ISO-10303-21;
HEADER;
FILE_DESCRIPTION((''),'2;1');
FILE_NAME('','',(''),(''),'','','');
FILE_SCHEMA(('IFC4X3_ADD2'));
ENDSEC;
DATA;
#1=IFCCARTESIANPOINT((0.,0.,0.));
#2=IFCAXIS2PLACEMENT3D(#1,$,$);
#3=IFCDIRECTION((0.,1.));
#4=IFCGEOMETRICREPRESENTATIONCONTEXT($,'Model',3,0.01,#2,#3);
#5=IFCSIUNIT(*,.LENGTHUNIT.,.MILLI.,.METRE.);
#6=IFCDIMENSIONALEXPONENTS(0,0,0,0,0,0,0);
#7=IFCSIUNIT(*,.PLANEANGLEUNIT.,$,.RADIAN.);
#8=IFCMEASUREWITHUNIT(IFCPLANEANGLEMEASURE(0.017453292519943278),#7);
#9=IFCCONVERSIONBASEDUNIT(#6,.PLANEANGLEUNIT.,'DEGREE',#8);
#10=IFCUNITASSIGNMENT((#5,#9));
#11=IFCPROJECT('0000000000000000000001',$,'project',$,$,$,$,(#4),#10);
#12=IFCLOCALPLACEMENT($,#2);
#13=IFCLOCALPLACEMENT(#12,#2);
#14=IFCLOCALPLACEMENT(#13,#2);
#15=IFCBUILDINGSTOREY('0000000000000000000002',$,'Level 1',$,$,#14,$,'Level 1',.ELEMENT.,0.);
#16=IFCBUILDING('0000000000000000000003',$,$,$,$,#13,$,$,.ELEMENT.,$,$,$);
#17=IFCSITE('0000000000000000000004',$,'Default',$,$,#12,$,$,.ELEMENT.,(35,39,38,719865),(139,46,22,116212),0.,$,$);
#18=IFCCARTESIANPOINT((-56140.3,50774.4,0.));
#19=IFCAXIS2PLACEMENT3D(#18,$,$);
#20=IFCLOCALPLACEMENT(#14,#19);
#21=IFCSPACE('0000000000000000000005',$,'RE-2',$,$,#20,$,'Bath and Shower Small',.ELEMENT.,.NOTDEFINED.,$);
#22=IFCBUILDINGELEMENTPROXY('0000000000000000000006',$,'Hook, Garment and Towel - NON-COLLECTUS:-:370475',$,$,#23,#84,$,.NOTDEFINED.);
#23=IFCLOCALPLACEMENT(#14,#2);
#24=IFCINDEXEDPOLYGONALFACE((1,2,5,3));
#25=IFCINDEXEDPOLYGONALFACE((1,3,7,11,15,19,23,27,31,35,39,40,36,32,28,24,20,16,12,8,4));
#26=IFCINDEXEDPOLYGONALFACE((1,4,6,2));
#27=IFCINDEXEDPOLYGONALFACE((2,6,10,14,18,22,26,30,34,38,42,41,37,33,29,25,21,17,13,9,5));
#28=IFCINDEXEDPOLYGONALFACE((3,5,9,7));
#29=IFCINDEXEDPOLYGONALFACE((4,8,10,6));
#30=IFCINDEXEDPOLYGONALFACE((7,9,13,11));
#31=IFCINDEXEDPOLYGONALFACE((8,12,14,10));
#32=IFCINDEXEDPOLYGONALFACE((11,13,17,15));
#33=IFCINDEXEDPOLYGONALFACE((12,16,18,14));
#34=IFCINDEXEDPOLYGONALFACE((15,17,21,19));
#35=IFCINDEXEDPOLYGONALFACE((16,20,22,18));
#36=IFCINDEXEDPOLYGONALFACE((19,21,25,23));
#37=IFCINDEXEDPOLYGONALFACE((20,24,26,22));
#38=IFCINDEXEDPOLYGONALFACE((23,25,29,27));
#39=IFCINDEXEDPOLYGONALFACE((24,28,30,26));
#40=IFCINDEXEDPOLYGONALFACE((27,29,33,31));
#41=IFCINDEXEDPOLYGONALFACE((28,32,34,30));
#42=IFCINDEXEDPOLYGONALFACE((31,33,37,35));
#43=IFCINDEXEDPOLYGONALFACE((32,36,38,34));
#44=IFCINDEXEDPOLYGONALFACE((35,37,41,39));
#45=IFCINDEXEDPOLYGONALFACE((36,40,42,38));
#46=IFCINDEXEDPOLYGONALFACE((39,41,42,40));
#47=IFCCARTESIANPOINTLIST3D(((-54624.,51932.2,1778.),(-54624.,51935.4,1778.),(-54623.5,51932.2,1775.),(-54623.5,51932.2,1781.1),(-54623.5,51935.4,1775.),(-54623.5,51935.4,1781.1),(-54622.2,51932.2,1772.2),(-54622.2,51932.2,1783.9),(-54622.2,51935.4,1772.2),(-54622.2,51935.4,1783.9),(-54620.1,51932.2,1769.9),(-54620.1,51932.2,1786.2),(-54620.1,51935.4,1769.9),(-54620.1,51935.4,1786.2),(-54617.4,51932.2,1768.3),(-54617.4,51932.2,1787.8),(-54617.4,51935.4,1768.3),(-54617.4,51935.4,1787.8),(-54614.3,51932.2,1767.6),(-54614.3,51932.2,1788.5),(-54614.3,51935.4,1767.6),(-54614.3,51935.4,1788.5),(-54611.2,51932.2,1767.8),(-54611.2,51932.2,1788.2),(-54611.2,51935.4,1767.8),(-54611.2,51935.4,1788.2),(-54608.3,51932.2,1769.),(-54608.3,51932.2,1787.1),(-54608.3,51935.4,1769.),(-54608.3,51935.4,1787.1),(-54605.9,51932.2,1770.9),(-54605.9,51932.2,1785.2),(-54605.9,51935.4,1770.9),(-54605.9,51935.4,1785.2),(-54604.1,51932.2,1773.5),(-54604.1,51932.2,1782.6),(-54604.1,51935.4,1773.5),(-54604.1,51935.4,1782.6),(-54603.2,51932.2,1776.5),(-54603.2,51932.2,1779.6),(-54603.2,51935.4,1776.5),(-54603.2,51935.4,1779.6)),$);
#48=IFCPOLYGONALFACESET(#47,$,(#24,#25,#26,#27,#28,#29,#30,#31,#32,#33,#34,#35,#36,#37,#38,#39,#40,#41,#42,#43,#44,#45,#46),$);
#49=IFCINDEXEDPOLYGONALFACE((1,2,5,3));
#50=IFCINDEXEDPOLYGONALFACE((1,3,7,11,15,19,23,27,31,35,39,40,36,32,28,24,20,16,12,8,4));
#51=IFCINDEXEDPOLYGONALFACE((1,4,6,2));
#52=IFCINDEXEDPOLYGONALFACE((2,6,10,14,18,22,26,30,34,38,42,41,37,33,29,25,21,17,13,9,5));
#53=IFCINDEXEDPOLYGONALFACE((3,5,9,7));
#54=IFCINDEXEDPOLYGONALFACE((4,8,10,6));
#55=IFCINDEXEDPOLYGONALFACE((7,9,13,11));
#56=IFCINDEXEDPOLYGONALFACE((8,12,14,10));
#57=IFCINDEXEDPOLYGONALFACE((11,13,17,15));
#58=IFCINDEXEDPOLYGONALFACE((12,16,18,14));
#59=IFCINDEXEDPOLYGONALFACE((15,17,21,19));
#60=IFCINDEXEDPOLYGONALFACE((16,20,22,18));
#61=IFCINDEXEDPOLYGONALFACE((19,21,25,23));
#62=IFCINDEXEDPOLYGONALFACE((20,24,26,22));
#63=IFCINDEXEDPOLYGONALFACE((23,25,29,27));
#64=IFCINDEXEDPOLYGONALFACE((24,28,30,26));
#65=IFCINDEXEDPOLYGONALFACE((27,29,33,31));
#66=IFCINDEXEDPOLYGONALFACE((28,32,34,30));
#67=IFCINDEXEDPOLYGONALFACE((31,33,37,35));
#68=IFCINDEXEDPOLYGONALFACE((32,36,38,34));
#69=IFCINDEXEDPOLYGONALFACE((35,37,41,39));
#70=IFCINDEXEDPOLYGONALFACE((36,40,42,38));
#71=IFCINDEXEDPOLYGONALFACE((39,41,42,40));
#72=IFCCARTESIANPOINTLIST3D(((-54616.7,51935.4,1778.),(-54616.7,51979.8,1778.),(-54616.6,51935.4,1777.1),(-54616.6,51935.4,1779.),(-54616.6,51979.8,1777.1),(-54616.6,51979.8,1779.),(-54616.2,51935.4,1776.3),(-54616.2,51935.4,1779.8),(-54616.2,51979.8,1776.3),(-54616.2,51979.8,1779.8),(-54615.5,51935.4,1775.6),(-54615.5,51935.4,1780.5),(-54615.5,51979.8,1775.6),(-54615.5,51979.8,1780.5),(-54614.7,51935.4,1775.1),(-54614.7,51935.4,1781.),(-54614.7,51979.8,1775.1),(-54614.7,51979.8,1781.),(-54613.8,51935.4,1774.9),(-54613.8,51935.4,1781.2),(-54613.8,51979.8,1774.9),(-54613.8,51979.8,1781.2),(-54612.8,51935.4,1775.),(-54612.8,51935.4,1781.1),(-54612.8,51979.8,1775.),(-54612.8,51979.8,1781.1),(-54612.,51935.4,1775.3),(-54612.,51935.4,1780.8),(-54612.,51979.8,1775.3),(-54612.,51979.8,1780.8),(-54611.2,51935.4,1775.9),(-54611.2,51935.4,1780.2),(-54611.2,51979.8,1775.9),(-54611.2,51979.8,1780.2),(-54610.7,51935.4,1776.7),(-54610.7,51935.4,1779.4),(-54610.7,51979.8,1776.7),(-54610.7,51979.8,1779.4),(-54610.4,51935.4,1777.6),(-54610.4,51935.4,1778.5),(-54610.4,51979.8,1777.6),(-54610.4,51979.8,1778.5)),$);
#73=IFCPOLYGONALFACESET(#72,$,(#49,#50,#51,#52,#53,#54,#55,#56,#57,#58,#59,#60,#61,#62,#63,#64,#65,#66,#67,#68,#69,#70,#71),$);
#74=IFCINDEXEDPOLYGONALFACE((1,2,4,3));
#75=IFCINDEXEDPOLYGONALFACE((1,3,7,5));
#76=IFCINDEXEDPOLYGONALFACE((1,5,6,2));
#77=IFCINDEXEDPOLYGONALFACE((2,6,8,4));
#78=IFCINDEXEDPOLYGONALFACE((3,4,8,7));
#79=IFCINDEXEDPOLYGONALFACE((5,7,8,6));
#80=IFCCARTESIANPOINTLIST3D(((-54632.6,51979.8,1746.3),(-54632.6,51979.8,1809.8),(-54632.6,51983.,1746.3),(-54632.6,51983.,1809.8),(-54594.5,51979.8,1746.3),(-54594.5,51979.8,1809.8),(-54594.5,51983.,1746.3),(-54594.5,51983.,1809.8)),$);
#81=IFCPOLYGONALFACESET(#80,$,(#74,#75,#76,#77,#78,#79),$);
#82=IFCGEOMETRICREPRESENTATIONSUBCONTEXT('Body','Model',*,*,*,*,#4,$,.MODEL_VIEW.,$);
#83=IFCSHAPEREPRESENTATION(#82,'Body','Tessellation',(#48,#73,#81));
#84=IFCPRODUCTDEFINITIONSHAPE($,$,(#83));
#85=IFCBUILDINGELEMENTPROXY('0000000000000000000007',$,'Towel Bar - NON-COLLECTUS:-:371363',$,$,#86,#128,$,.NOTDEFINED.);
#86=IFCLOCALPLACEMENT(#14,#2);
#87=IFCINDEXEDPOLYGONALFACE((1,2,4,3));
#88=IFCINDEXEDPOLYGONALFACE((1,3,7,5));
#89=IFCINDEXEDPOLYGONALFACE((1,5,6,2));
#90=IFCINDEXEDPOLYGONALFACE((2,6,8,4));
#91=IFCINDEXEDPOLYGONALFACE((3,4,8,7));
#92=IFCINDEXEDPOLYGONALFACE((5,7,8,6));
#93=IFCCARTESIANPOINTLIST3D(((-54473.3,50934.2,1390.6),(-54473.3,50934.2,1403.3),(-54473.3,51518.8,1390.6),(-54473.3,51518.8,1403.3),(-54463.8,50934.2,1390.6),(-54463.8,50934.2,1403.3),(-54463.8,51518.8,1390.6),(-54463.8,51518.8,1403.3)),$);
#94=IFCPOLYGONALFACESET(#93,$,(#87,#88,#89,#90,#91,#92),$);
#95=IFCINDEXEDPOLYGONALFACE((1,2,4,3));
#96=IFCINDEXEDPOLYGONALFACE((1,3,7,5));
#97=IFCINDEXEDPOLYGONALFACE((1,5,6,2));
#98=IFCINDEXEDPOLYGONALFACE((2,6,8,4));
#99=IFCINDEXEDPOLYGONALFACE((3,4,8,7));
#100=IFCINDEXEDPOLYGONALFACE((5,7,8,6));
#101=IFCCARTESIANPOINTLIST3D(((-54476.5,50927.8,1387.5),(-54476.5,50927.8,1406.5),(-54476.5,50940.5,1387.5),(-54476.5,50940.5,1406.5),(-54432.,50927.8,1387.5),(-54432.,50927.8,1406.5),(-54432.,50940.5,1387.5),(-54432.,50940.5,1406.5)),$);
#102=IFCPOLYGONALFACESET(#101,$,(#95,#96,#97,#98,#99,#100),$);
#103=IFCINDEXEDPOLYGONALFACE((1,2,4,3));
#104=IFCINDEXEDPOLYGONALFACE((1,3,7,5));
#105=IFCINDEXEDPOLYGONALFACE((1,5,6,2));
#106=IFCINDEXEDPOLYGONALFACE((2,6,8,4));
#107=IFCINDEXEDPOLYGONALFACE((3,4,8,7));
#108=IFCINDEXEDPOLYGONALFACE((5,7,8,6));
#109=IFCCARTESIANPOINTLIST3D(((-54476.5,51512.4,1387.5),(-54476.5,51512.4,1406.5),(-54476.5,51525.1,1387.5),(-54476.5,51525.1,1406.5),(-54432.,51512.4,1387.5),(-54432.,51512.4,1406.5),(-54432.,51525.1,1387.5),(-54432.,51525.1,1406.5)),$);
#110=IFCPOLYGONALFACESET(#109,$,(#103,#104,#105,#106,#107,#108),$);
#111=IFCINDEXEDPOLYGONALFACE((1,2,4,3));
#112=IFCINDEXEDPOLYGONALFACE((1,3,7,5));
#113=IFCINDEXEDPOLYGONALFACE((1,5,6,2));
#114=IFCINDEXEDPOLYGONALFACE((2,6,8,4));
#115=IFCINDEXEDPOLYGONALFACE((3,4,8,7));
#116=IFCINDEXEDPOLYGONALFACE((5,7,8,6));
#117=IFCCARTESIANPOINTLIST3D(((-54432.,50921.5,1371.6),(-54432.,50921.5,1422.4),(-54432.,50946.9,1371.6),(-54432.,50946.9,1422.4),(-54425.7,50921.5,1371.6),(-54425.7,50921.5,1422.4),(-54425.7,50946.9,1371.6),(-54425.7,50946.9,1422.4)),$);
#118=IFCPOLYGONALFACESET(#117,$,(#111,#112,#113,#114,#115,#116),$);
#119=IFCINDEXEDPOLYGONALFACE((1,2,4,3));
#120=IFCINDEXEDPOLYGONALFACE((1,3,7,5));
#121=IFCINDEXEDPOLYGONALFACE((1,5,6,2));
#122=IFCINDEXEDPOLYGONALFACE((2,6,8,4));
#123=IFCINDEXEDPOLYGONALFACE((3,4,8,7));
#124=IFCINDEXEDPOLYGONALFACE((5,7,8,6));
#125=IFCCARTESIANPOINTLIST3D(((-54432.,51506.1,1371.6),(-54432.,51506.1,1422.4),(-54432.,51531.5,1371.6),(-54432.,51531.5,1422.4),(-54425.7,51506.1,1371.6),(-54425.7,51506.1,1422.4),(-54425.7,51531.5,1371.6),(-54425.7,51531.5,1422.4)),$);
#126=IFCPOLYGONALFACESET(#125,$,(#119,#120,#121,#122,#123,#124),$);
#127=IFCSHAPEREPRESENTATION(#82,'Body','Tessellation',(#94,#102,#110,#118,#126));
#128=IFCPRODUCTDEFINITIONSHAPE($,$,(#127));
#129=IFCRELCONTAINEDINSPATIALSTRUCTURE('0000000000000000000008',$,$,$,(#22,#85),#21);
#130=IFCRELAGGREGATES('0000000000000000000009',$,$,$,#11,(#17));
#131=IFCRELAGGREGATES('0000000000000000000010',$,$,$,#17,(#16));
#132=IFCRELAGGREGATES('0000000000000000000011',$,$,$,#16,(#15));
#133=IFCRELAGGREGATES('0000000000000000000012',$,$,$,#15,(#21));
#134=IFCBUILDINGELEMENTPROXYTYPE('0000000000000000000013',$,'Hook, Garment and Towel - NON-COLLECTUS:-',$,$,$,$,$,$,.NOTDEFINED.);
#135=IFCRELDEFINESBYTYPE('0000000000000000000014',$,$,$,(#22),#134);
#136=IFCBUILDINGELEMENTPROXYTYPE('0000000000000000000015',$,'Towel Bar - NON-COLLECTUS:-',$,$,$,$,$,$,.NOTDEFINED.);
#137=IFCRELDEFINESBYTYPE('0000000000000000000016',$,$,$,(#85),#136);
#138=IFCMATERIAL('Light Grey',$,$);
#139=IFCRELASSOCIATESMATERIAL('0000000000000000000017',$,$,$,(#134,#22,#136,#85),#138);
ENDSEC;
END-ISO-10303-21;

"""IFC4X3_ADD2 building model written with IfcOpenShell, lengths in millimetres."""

from ifc_helpers import new_model, entity, si_unit, converted_unit, direction, frame, frame_2d, origin, origin_2d_with_axis, place, context, subcontext, project, spatial, rectangle, circle, extrude, source, transform, mapped, material, type_object, type_shapes, element, save


model = new_model("IFC4X3_ADD2")

# Units and contexts
model_context = context("Model", 3, precision=0.01, world=origin(), true_north=direction((0.0, 1.0)))
body_context = subcontext(model_context, "Body", "Model", "MODEL_VIEW")
ifc_project = project(units=[si_unit("LENGTHUNIT", "METRE", prefix="MILLI"), converted_unit("PLANEANGLEUNIT", "DEGREE", entity("IfcPlaneAngleMeasure", 0.017453292519943278), si_unit("PLANEANGLEUNIT", "RADIAN"), dimensions=[0, 0, 0, 0, 0, 0, 0])], contexts=[model_context])

# Site, building, storey
site_placement = place(None, origin())
site = spatial("IfcSite", under=ifc_project, at=site_placement, Name="Default", CompositionType="ELEMENT", RefLatitude=(35, 39, 38, 719865), RefLongitude=(139, 46, 22, 116212), RefElevation=0.0)
building_placement = place(site_placement, origin())
building = spatial("IfcBuilding", under=site, at=building_placement, CompositionType="ELEMENT")
storey_placement = place(building_placement, origin())
storey = spatial("IfcBuildingStorey", under=building, at=storey_placement, Name="Level 1", LongName="Level 1", CompositionType="ELEMENT", Elevation=0.0)

# Shared definitions
space_1_placement = place(storey_placement, frame((-56140.3, 50774.4, 0.0)))
space_1 = spatial("IfcSpace", under=storey, at=space_1_placement, Name="RE-2", LongName="Bath and Shower Small", CompositionType="ELEMENT", PredefinedType="NOTDEFINED")

# Building element proxies
ifc_material_1 = material(Name="Light Grey")
building_element_proxy_type_1 = type_object("IfcBuildingElementProxyType", Name="Hook, Garment and Towel - NON-COLLECTUS:-", PredefinedType="NOTDEFINED", material=ifc_material_1)
shared_shape_1 = source(origin(), body_context, "Body", "SweptSolid", [
    extrude(circle(Radius=10.5, at=frame_2d((0.0, 0.0), x_axis=(1.0, 0.0))), frame((19.1, -50.8, 31.8), z_axis=(0.0, 1.0, 0.0), x_axis=(-1.0, 0.0, 0.0)), (0.0, 0.0, 1.0), 3.2),
    extrude(circle(Radius=3.2, at=frame_2d((0.0, 0.0), x_axis=(1.0, 0.0))), frame((19.1, -47.6, 31.8), z_axis=(0.0, 1.0, 0.0), x_axis=(-1.0, 0.0, 0.0)), (0.0, 0.0, 1.0), 44.5),
    extrude(rectangle(XDim=3.2, YDim=38.1, at=origin_2d_with_axis()), frame((19.1, -1.6, 0.0), z_axis=(0.0, 0.0, 1.0), x_axis=(0.0, 1.0, 0.0)), (0.0, 0.0, 1.0), 63.5),
])
type_shapes(building_element_proxy_type_1, [shared_shape_1])
proxy_1_placement = place(space_1_placement, frame((1507.7, 1208.6, 1746.3)))
element("IfcBuildingElementProxy", 1, at=proxy_1_placement, inside=space_1, type_object=building_element_proxy_type_1, material=ifc_material_1, Name="Hook, Garment and Towel - NON-COLLECTUS:-:370475", PredefinedType="NOTDEFINED", context=body_context, shape_type="MappedRepresentation", body=[
    mapped(shared_shape_1, transform((0.0, 0.0, 0.0), scale=1.0)),
])
building_element_proxy_type_2 = type_object("IfcBuildingElementProxyType", Name="Towel Bar - NON-COLLECTUS:-", PredefinedType="NOTDEFINED", material=ifc_material_1)
shared_shape_2 = source(origin(), body_context, "Body", "SweptSolid", [
    extrude(rectangle(XDim=584.6, YDim=9.5, at=origin_2d_with_axis()), frame((0.0, -42.9, 19.1), z_axis=(0.0, 0.0, 1.0), x_axis=(-1.0, 0.0, 0.0)), (0.0, 0.0, 1.0), 12.7),
    extrude(rectangle(XDim=44.5, YDim=12.7, at=frame_2d((0.0, 0.0), x_axis=(1.0, 0.0))), frame((292.3, -28.6, 15.9), z_axis=(0.0, 0.0, 1.0), x_axis=(0.0, -1.0, 0.0)), (0.0, 0.0, 1.0), 19.1),
    extrude(rectangle(XDim=44.5, YDim=12.7, at=origin_2d_with_axis()), frame((-292.3, -28.6, 15.9), z_axis=(0.0, 0.0, 1.0), x_axis=(0.0, -1.0, 0.0)), (0.0, 0.0, 1.0), 19.1),
    extrude(rectangle(XDim=6.3, YDim=25.4, at=frame_2d((0.0, 0.0), x_axis=(1.0, 0.0))), frame((292.3, -3.2, 0.0), z_axis=(0.0, 0.0, 1.0), x_axis=(0.0, -1.0, 0.0)), (0.0, 0.0, 1.0), 50.8),
    extrude(rectangle(XDim=6.3, YDim=25.4, at=frame_2d((0.0, 0.0), x_axis=(1.0, 0.0))), frame((-292.3, -3.2, 0.0), z_axis=(0.0, 0.0, 1.0), x_axis=(0.0, -1.0, 0.0)), (0.0, 0.0, 1.0), 50.8),
])
type_shapes(building_element_proxy_type_2, [shared_shape_2])
proxy_2_placement = place(space_1_placement, frame((1714.6, 452.0, 1371.6), z_axis=(0.0, 0.0, 1.0), x_axis=(0.000001, -1.0, 0.0)))
element("IfcBuildingElementProxy", 2, at=proxy_2_placement, inside=space_1, type_object=building_element_proxy_type_2, material=ifc_material_1, Name="Towel Bar - NON-COLLECTUS:-:371363", PredefinedType="NOTDEFINED", context=body_context, shape_type="MappedRepresentation", body=[
    mapped(shared_shape_2, transform((0.0, 0.0, 0.0), scale=1.0)),
])

save(model, "model.ifc")
